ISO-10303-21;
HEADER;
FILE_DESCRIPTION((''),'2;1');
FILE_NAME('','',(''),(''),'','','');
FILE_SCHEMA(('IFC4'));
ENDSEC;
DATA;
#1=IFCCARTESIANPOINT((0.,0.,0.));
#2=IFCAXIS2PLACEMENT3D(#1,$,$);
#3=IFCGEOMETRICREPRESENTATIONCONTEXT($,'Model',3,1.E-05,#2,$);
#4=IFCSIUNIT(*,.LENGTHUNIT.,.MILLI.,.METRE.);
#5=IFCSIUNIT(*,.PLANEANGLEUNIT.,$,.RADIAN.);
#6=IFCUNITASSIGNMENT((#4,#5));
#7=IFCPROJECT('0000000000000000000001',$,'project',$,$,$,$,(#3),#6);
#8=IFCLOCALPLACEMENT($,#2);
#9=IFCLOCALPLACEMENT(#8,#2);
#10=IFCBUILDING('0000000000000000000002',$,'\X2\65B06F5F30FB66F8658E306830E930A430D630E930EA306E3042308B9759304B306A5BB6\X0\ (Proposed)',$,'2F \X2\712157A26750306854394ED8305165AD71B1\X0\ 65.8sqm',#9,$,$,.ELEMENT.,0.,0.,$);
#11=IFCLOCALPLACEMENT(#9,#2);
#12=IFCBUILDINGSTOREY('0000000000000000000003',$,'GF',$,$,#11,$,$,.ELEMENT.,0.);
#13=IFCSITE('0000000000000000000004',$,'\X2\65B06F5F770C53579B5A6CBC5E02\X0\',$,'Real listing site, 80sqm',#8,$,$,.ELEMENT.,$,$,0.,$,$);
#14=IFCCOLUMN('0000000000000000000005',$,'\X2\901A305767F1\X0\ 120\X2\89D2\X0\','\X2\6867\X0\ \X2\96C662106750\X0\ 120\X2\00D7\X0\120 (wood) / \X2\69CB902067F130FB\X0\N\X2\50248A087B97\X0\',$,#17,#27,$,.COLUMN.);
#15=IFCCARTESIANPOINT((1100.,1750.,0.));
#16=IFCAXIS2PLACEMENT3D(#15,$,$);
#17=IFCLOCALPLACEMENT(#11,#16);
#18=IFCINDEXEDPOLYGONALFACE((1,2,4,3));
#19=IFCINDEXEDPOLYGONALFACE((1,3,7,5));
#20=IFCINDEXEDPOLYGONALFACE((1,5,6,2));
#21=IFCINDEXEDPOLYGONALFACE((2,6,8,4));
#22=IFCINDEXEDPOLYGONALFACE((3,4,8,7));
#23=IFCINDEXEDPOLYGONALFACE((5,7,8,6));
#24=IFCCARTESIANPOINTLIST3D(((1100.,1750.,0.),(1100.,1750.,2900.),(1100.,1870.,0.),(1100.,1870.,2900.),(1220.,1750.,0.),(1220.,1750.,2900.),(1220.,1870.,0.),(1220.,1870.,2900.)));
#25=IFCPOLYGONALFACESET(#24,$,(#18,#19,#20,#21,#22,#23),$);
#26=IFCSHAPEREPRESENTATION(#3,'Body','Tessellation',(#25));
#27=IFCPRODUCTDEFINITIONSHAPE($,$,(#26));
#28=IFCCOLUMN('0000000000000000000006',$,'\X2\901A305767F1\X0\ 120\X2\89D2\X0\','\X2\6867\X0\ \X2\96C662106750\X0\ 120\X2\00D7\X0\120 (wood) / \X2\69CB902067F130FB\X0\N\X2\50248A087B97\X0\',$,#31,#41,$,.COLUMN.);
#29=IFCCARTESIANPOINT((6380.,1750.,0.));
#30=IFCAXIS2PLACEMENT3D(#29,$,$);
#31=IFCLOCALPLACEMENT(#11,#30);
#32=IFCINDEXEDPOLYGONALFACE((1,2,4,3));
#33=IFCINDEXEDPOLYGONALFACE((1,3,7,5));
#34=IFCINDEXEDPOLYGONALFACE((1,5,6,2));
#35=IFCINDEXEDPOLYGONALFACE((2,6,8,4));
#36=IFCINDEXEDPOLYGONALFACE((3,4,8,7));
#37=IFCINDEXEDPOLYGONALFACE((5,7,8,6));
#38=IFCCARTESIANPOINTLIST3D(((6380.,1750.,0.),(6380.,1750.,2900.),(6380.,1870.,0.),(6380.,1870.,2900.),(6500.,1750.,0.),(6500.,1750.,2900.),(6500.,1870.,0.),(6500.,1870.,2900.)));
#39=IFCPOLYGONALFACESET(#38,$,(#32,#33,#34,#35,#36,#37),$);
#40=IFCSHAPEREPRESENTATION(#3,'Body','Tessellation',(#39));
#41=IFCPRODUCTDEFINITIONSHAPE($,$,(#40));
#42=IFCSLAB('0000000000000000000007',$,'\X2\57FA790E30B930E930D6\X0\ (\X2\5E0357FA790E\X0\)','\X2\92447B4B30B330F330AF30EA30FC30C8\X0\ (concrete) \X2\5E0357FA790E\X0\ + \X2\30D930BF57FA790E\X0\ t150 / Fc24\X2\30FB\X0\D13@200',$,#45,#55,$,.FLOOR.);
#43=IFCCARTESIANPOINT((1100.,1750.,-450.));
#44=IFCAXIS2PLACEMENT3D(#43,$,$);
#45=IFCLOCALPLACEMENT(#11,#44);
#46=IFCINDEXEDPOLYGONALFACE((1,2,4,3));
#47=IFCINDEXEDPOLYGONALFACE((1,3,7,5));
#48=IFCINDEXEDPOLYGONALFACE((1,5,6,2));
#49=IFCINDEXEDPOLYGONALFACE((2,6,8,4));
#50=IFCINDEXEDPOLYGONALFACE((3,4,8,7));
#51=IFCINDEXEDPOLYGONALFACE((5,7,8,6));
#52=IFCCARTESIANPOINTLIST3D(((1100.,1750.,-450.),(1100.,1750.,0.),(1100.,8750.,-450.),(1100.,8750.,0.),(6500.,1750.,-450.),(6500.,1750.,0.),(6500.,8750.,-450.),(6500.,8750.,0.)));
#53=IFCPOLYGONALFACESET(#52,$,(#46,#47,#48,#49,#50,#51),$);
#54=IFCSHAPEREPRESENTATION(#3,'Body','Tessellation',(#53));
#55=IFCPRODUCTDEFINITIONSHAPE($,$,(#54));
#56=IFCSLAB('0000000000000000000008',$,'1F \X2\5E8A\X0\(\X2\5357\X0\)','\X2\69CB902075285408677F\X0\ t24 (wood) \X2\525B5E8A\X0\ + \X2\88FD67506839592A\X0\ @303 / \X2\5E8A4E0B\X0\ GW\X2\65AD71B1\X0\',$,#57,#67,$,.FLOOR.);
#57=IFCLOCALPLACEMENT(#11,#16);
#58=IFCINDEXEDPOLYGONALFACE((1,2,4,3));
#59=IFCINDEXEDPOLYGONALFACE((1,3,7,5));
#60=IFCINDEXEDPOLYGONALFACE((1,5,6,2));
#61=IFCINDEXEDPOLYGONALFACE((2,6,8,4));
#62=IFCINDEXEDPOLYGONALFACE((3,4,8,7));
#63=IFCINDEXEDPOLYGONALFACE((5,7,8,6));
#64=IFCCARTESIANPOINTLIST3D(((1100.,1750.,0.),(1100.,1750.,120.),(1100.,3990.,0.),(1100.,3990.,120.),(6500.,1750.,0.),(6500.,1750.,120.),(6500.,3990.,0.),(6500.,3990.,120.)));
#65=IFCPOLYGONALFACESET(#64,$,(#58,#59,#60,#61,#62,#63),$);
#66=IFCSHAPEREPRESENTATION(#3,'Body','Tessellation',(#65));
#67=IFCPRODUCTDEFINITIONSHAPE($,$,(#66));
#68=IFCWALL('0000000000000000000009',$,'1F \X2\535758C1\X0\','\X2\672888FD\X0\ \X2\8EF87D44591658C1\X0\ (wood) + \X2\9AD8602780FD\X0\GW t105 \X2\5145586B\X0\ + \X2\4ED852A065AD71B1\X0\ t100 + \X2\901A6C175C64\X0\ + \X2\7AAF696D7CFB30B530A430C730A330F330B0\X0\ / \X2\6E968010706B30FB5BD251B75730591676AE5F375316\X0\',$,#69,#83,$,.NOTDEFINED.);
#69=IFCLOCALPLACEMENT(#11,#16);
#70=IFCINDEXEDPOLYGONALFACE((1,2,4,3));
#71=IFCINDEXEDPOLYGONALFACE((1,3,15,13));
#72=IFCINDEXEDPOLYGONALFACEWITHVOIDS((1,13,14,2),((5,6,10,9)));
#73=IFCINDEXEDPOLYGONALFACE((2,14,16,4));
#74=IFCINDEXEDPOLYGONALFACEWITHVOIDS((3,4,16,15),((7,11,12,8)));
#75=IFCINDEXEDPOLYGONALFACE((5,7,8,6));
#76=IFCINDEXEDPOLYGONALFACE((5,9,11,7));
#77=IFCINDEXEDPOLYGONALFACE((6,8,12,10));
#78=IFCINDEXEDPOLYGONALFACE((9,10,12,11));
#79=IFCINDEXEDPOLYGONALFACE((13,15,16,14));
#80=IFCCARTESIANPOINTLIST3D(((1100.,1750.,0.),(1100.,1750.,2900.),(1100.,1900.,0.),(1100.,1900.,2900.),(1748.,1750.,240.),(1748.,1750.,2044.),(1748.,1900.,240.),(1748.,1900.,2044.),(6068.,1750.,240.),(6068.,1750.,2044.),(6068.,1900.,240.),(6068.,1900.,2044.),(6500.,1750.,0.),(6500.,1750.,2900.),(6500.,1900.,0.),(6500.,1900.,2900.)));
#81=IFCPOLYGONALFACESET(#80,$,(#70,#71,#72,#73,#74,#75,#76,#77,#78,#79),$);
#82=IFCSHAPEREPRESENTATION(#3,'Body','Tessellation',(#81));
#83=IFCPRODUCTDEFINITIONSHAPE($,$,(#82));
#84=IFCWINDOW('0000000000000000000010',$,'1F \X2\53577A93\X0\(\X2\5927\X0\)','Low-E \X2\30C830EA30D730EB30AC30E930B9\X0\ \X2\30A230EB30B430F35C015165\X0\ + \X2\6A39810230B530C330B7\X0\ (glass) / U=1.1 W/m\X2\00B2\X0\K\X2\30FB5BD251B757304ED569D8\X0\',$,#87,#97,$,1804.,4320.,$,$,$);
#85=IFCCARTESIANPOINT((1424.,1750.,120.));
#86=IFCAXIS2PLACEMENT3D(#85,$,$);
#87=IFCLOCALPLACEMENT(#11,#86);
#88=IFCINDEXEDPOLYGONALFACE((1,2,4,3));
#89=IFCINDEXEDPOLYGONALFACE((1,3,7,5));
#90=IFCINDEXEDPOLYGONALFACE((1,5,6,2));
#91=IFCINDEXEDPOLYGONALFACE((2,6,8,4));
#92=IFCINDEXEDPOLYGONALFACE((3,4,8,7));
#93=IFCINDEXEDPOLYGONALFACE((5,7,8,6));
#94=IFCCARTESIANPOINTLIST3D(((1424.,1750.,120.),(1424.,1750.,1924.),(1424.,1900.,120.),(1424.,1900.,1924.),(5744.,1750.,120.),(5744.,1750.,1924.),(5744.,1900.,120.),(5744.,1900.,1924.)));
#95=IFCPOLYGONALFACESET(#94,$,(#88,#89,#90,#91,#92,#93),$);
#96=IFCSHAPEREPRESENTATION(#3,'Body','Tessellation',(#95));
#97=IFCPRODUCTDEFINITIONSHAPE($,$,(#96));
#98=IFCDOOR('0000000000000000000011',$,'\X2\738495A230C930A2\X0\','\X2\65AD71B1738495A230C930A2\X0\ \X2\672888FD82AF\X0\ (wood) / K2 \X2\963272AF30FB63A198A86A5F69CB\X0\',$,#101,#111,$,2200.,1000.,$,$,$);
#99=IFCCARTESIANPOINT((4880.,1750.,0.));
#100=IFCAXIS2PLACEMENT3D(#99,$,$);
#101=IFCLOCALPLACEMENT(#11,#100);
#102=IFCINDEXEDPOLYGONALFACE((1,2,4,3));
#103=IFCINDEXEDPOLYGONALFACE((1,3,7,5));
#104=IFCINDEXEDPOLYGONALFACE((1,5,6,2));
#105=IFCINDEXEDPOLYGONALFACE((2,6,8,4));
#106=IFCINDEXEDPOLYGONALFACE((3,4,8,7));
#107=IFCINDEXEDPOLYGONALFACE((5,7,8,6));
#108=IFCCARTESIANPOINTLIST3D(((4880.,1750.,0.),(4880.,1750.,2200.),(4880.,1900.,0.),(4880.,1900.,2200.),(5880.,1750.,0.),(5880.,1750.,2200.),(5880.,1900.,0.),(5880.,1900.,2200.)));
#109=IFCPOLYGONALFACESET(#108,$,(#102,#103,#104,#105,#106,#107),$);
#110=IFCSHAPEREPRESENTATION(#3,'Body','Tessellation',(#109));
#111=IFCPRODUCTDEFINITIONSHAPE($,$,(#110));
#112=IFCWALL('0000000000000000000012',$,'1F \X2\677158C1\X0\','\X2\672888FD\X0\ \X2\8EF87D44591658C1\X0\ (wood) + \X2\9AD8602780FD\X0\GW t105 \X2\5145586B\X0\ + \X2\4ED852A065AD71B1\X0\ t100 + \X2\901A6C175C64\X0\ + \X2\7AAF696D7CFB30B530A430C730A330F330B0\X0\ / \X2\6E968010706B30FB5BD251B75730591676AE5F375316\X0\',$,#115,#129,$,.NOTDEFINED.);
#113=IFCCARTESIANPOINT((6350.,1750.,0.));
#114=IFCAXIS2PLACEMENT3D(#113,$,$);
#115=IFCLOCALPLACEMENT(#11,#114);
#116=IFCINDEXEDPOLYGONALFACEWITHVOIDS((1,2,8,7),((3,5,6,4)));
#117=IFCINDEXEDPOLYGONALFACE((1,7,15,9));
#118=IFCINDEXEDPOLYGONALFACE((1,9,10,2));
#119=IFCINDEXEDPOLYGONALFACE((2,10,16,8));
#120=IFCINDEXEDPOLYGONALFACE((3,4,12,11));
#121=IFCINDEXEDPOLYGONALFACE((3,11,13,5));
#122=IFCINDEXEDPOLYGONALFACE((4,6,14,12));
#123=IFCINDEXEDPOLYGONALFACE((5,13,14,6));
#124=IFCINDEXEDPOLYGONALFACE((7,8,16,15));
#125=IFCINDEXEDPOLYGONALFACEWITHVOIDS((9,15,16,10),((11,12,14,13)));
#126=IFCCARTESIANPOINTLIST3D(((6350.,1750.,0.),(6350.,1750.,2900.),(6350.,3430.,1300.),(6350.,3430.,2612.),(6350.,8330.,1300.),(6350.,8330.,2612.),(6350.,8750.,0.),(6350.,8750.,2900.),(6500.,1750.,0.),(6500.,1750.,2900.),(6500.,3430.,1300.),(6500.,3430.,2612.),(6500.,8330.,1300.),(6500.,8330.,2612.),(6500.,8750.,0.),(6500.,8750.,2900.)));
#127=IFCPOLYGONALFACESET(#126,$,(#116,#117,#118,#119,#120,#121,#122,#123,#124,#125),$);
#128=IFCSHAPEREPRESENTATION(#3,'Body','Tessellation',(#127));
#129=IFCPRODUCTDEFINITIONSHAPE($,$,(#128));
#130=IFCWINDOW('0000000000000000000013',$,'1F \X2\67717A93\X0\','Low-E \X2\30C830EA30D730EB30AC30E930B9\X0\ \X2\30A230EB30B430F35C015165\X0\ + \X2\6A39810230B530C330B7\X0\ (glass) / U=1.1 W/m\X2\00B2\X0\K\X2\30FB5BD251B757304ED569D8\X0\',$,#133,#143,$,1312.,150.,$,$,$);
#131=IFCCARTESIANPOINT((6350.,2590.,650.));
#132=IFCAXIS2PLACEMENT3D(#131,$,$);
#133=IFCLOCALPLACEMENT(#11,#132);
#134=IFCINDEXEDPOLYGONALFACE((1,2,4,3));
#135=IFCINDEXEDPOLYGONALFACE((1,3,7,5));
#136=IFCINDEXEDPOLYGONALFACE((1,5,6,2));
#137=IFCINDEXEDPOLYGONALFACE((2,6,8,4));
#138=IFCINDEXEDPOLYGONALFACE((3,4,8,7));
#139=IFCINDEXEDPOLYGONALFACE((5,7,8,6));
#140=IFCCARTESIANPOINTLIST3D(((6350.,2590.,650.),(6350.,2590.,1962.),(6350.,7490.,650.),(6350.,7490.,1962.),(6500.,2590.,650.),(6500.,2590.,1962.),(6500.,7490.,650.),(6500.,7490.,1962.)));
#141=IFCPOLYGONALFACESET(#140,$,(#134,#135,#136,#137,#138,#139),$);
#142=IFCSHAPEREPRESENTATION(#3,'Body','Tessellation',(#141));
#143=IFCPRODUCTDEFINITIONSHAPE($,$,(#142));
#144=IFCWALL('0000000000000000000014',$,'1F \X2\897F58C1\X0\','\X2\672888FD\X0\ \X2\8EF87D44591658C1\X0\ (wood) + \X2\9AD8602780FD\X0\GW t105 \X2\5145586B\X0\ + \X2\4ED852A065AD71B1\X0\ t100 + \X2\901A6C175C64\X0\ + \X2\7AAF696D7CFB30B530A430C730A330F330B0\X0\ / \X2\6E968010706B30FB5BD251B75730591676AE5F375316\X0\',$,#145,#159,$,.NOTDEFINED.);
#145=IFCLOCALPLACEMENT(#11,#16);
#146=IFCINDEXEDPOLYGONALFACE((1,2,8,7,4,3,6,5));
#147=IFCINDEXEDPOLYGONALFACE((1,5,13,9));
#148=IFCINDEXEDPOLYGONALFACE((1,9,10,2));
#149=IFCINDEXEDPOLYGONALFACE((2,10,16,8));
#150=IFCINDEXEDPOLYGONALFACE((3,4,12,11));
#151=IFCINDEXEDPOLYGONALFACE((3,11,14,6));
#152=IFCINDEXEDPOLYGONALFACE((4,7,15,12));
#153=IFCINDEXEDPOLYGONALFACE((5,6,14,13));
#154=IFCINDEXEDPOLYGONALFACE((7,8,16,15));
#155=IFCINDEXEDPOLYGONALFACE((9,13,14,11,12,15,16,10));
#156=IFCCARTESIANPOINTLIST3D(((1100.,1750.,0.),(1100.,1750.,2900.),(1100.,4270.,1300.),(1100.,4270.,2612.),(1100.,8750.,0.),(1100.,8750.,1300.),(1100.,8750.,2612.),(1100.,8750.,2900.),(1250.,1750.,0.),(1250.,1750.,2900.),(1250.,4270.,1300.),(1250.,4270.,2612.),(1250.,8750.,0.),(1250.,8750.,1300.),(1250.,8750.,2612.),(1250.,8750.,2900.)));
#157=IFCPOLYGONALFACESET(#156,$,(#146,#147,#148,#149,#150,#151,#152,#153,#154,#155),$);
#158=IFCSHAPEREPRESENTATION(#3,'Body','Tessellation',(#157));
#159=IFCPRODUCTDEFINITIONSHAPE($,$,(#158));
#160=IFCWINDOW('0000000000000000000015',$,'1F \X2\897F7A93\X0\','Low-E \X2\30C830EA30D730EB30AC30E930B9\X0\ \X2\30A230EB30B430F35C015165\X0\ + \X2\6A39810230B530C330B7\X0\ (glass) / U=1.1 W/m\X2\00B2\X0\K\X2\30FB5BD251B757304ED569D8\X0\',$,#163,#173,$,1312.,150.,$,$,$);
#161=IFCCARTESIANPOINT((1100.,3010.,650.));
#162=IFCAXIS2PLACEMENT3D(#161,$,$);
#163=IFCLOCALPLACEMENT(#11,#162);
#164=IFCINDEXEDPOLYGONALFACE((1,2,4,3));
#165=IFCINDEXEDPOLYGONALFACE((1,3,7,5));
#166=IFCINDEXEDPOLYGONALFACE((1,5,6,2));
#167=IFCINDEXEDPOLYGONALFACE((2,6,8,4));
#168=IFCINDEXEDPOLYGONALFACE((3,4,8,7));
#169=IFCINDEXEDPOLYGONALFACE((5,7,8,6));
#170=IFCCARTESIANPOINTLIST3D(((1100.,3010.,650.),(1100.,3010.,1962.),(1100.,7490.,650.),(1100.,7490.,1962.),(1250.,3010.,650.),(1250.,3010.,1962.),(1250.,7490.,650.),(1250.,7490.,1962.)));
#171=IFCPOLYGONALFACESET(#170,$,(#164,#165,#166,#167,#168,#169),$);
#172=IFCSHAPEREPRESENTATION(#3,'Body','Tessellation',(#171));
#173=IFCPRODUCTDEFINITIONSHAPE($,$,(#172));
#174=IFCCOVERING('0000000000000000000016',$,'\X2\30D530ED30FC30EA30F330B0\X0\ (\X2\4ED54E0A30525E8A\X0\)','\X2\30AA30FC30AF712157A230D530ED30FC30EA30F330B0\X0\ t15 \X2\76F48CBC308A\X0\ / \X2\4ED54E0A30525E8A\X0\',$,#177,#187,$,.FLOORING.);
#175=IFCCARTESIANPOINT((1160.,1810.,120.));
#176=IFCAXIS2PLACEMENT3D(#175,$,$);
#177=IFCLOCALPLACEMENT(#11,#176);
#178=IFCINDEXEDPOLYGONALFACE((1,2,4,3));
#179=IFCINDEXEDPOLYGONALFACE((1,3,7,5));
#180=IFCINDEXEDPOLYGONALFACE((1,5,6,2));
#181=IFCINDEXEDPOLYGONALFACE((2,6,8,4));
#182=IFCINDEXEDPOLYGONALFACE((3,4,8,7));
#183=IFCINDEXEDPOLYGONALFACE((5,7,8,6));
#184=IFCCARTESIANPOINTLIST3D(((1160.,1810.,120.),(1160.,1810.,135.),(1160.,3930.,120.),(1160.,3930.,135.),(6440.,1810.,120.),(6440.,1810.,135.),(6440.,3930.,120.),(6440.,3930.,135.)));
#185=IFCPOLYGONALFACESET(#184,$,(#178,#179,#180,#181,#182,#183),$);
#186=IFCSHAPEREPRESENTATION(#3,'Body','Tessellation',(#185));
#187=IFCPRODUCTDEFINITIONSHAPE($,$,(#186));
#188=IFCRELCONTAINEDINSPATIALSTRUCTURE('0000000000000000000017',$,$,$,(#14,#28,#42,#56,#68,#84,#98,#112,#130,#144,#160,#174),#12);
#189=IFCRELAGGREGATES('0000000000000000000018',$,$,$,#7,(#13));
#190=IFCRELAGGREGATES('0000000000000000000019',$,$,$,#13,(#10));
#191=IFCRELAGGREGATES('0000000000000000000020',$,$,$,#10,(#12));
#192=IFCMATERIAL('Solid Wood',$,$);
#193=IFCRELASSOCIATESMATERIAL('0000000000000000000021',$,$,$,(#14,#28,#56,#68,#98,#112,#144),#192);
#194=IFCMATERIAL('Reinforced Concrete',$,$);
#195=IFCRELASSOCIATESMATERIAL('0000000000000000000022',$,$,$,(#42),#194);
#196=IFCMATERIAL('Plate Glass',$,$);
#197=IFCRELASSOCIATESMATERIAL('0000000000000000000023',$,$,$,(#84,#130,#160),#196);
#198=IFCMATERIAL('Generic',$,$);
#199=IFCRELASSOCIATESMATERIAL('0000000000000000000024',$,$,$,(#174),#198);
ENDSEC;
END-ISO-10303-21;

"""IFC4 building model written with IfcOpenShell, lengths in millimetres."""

from ifc_helpers import new_model, si_unit, frame, frame_2d, origin, place, context, project, spatial, rectangle, extrude, material, element, fill, save


model = new_model("IFC4")

# Units and contexts
model_context = context("Model", 3, precision=1e-05, world=origin())
ifc_project = project(units=[si_unit("LENGTHUNIT", "METRE", prefix="MILLI"), si_unit("PLANEANGLEUNIT", "RADIAN")], contexts=[model_context])

# Site, building, storey
site_placement = place(None, origin())
site = spatial("IfcSite", under=ifc_project, at=site_placement, Name="新潟県南魚沼市", ObjectType="Real listing site, 80sqm", CompositionType="ELEMENT", RefElevation=0.0)
building_placement = place(site_placement, origin())
building = spatial("IfcBuilding", under=site, at=building_placement, Name="新潟・書斎とライブラリのある静かな家 (Proposed)", ObjectType="2F 無垢材と吹付け断熱 65.8sqm", CompositionType="ELEMENT", ElevationOfRefHeight=0.0, ElevationOfTerrain=0.0)
storey_placement = place(building_placement, origin())
storey = spatial("IfcBuildingStorey", under=building, at=storey_placement, Name="GF", CompositionType="ELEMENT", Elevation=0.0)

# Columns
ifc_material_1 = material(Name="Solid Wood")
column_1_placement = place(storey_placement, frame((1100.0, 1750.0, 0.0)))
element("IfcColumn", 1, at=column_1_placement, inside=storey, material=ifc_material_1, Name="通し柱 120角", Description="桧 集成材 120×120 (wood) / 構造柱・N値計算", PredefinedType="COLUMN", context=model_context, shape_type="SweptSolid", body=[
    extrude(rectangle(XDim=120.0, YDim=120.0, at=frame_2d((60.0, 60.0))), frame((1100.0, 1750.0, 0.0)), (0.0, 0.0, 1.0), 2900.0),
])
column_2_placement = place(storey_placement, frame((6380.0, 1750.0, 0.0)))
element("IfcColumn", 2, at=column_2_placement, inside=storey, material=ifc_material_1, Name="通し柱 120角", Description="桧 集成材 120×120 (wood) / 構造柱・N値計算", PredefinedType="COLUMN", context=model_context, shape_type="SweptSolid", body=[
    extrude(rectangle(XDim=120.0, YDim=120.0, at=frame_2d((60.0, 60.0))), frame((6380.0, 1750.0, 0.0)), (0.0, 0.0, 1.0), 2900.0),
])

# Slabs
ifc_material_2 = material(Name="Reinforced Concrete")
slab_1_placement = place(storey_placement, frame((1100.0, 1750.0, -450.0)))
element("IfcSlab", 3, at=slab_1_placement, inside=storey, material=ifc_material_2, Name="基礎スラブ (布基礎)", Description="鉄筋コンクリート (concrete) 布基礎 + ベタ基礎 t150 / Fc24・D13@200", PredefinedType="FLOOR", context=model_context, shape_type="SweptSolid", body=[
    extrude(rectangle(XDim=5400.0, YDim=7000.0, at=frame_2d((2700.0, 3500.0))), frame((1100.0, 1750.0, -450.0)), (0.0, 0.0, 1.0), 450.0),
])
slab_2_placement = place(storey_placement, frame((1100.0, 1750.0, 0.0)))
element("IfcSlab", 4, at=slab_2_placement, inside=storey, material=ifc_material_1, Name="1F 床(南)", Description="構造用合板 t24 (wood) 剛床 + 製材根太 @303 / 床下 GW断熱", PredefinedType="FLOOR", context=model_context, shape_type="SweptSolid", body=[
    extrude(rectangle(XDim=5400.0, YDim=2240.0, at=frame_2d((2700.0, 1120.0))), frame((1100.0, 1750.0, 0.0)), (0.0, 0.0, 1.0), 120.0),
])

# Wall, openings, window, door
wall_1_placement = place(storey_placement, frame((1100.0, 1750.0, 0.0)))
wall_1 = element("IfcWall", 5, at=wall_1_placement, inside=storey, material=ifc_material_1, Name="1F 南壁", Description="木製 軸組外壁 (wood) + 高性能GW t105 充填 + 付加断熱 t100 + 通気層 + 窯業系サイディング / 準耐火・寒冷地外皮強化", PredefinedType="NOTDEFINED", context=model_context, shape_type="SweptSolid", body=[
    extrude(rectangle(XDim=5400.0, YDim=150.0, at=frame_2d((2700.0, 75.0))), frame((1100.0, 1750.0, 0.0)), (0.0, 0.0, 1.0), 2900.0),
])
opening_1_placement = place(storey_placement, frame((1424.0, 1750.0, 120.0)))
opening_1 = element("IfcOpeningElement", 6, at=opening_1_placement, cuts=wall_1, PredefinedType="NOTDEFINED", context=model_context, shape_type="SweptSolid", body=[
    extrude(rectangle(XDim=4320.0, YDim=150.0, at=frame_2d((2160.0, 75.0))), frame((1424.0, 1750.0, 120.0)), (0.0, 0.0, 1.0), 1804.0),
])
opening_2_placement = place(storey_placement, frame((4880.0, 1750.0, 0.0)))
opening_2 = element("IfcOpeningElement", 7, at=opening_2_placement, cuts=wall_1, PredefinedType="NOTDEFINED", context=model_context, shape_type="SweptSolid", body=[
    extrude(rectangle(XDim=1000.0, YDim=150.0, at=frame_2d((500.0, 75.0))), frame((4880.0, 1750.0, 0.0)), (0.0, 0.0, 1.0), 2200.0),
])
ifc_material_3 = material(Name="Plate Glass")
window_1_placement = place(storey_placement, frame((1424.0, 1750.0, 120.0)))
window_1 = element("IfcWindow", 8, at=window_1_placement, inside=storey, material=ifc_material_3, Name="1F 南窓(大)", Description="Low-E トリプルガラス アルゴン封入 + 樹脂サッシ (glass) / U=1.1 W/m²K・寒冷地仕様", OverallHeight=1804.0, OverallWidth=4320.0, context=model_context, shape_type="SweptSolid", body=[
    extrude(rectangle(XDim=4320.0, YDim=150.0, at=frame_2d((2160.0, 75.0))), frame((1424.0, 1750.0, 120.0)), (0.0, 0.0, 1.0), 1804.0),
])
fill(opening_1, window_1)
door_placement = place(storey_placement, frame((4880.0, 1750.0, 0.0)))
door = element("IfcDoor", 9, at=door_placement, inside=storey, material=ifc_material_1, Name="玄関ドア", Description="断熱玄関ドア 木製芯 (wood) / K2 防犯・採風機構", OverallHeight=2200.0, OverallWidth=1000.0, context=model_context, shape_type="SweptSolid", body=[
    extrude(rectangle(XDim=1000.0, YDim=150.0, at=frame_2d((500.0, 75.0))), frame((4880.0, 1750.0, 0.0)), (0.0, 0.0, 1.0), 2200.0),
])
fill(opening_2, door)

# Walls, openings, windows
wall_2_placement = place(storey_placement, frame((6350.0, 1750.0, 0.0)))
wall_2 = element("IfcWall", 10, at=wall_2_placement, inside=storey, material=ifc_material_1, Name="1F 東壁", Description="木製 軸組外壁 (wood) + 高性能GW t105 充填 + 付加断熱 t100 + 通気層 + 窯業系サイディング / 準耐火・寒冷地外皮強化", PredefinedType="NOTDEFINED", context=model_context, shape_type="SweptSolid", body=[
    extrude(rectangle(XDim=150.0, YDim=7000.0, at=frame_2d((75.0, 3500.0))), frame((6350.0, 1750.0, 0.0)), (0.0, 0.0, 1.0), 2900.0),
])
opening_3_placement = place(storey_placement, frame((6350.0, 2590.0, 650.0)))
opening_3 = element("IfcOpeningElement", 11, at=opening_3_placement, cuts=wall_2, PredefinedType="NOTDEFINED", context=model_context, shape_type="SweptSolid", body=[
    extrude(rectangle(XDim=150.0, YDim=4900.0, at=frame_2d((75.0, 2450.0))), frame((6350.0, 2590.0, 650.0)), (0.0, 0.0, 1.0), 1312.0),
])
window_2_placement = place(storey_placement, frame((6350.0, 2590.0, 650.0)))
window_2 = element("IfcWindow", 12, at=window_2_placement, inside=storey, material=ifc_material_3, Name="1F 東窓", Description="Low-E トリプルガラス アルゴン封入 + 樹脂サッシ (glass) / U=1.1 W/m²K・寒冷地仕様", OverallHeight=1312.0, OverallWidth=150.0, context=model_context, shape_type="SweptSolid", body=[
    extrude(rectangle(XDim=150.0, YDim=4900.0, at=frame_2d((75.0, 2450.0))), frame((6350.0, 2590.0, 650.0)), (0.0, 0.0, 1.0), 1312.0),
])
fill(opening_3, window_2)
wall_3_placement = place(storey_placement, frame((1100.0, 1750.0, 0.0)))
wall_3 = element("IfcWall", 13, at=wall_3_placement, inside=storey, material=ifc_material_1, Name="1F 西壁", Description="木製 軸組外壁 (wood) + 高性能GW t105 充填 + 付加断熱 t100 + 通気層 + 窯業系サイディング / 準耐火・寒冷地外皮強化", PredefinedType="NOTDEFINED", context=model_context, shape_type="SweptSolid", body=[
    extrude(rectangle(XDim=150.0, YDim=7000.0, at=frame_2d((75.0, 3500.0))), frame((1100.0, 1750.0, 0.0)), (0.0, 0.0, 1.0), 2900.0),
])
opening_4_placement = place(storey_placement, frame((1100.0, 3010.0, 650.0)))
opening_4 = element("IfcOpeningElement", 14, at=opening_4_placement, cuts=wall_3, PredefinedType="NOTDEFINED", context=model_context, shape_type="SweptSolid", body=[
    extrude(rectangle(XDim=150.0, YDim=4480.0, at=frame_2d((75.0, 2240.0))), frame((1100.0, 3010.0, 650.0)), (0.0, 0.0, 1.0), 1312.0),
])
window_3_placement = place(storey_placement, frame((1100.0, 3010.0, 650.0)))
window_3 = element("IfcWindow", 15, at=window_3_placement, inside=storey, material=ifc_material_3, Name="1F 西窓", Description="Low-E トリプルガラス アルゴン封入 + 樹脂サッシ (glass) / U=1.1 W/m²K・寒冷地仕様", OverallHeight=1312.0, OverallWidth=150.0, context=model_context, shape_type="SweptSolid", body=[
    extrude(rectangle(XDim=150.0, YDim=4480.0, at=frame_2d((75.0, 2240.0))), frame((1100.0, 3010.0, 650.0)), (0.0, 0.0, 1.0), 1312.0),
])
fill(opening_4, window_3)

# Covering
ifc_material_4 = material(Name="Generic")
covering_1_placement = place(storey_placement, frame((1160.0, 1810.0, 120.0)))
element("IfcCovering", 16, at=covering_1_placement, inside=storey, material=ifc_material_4, Name="フローリング (仕上げ床)", Description="オーク無垢フローリング t15 直貼り / 仕上げ床", PredefinedType="FLOORING", context=model_context, shape_type="SweptSolid", body=[
    extrude(rectangle(XDim=5280.0, YDim=2120.0, at=frame_2d((2640.0, 1060.0))), frame((1160.0, 1810.0, 120.0)), (0.0, 0.0, 1.0), 15.0),
])

save(model, "model.ifc")
